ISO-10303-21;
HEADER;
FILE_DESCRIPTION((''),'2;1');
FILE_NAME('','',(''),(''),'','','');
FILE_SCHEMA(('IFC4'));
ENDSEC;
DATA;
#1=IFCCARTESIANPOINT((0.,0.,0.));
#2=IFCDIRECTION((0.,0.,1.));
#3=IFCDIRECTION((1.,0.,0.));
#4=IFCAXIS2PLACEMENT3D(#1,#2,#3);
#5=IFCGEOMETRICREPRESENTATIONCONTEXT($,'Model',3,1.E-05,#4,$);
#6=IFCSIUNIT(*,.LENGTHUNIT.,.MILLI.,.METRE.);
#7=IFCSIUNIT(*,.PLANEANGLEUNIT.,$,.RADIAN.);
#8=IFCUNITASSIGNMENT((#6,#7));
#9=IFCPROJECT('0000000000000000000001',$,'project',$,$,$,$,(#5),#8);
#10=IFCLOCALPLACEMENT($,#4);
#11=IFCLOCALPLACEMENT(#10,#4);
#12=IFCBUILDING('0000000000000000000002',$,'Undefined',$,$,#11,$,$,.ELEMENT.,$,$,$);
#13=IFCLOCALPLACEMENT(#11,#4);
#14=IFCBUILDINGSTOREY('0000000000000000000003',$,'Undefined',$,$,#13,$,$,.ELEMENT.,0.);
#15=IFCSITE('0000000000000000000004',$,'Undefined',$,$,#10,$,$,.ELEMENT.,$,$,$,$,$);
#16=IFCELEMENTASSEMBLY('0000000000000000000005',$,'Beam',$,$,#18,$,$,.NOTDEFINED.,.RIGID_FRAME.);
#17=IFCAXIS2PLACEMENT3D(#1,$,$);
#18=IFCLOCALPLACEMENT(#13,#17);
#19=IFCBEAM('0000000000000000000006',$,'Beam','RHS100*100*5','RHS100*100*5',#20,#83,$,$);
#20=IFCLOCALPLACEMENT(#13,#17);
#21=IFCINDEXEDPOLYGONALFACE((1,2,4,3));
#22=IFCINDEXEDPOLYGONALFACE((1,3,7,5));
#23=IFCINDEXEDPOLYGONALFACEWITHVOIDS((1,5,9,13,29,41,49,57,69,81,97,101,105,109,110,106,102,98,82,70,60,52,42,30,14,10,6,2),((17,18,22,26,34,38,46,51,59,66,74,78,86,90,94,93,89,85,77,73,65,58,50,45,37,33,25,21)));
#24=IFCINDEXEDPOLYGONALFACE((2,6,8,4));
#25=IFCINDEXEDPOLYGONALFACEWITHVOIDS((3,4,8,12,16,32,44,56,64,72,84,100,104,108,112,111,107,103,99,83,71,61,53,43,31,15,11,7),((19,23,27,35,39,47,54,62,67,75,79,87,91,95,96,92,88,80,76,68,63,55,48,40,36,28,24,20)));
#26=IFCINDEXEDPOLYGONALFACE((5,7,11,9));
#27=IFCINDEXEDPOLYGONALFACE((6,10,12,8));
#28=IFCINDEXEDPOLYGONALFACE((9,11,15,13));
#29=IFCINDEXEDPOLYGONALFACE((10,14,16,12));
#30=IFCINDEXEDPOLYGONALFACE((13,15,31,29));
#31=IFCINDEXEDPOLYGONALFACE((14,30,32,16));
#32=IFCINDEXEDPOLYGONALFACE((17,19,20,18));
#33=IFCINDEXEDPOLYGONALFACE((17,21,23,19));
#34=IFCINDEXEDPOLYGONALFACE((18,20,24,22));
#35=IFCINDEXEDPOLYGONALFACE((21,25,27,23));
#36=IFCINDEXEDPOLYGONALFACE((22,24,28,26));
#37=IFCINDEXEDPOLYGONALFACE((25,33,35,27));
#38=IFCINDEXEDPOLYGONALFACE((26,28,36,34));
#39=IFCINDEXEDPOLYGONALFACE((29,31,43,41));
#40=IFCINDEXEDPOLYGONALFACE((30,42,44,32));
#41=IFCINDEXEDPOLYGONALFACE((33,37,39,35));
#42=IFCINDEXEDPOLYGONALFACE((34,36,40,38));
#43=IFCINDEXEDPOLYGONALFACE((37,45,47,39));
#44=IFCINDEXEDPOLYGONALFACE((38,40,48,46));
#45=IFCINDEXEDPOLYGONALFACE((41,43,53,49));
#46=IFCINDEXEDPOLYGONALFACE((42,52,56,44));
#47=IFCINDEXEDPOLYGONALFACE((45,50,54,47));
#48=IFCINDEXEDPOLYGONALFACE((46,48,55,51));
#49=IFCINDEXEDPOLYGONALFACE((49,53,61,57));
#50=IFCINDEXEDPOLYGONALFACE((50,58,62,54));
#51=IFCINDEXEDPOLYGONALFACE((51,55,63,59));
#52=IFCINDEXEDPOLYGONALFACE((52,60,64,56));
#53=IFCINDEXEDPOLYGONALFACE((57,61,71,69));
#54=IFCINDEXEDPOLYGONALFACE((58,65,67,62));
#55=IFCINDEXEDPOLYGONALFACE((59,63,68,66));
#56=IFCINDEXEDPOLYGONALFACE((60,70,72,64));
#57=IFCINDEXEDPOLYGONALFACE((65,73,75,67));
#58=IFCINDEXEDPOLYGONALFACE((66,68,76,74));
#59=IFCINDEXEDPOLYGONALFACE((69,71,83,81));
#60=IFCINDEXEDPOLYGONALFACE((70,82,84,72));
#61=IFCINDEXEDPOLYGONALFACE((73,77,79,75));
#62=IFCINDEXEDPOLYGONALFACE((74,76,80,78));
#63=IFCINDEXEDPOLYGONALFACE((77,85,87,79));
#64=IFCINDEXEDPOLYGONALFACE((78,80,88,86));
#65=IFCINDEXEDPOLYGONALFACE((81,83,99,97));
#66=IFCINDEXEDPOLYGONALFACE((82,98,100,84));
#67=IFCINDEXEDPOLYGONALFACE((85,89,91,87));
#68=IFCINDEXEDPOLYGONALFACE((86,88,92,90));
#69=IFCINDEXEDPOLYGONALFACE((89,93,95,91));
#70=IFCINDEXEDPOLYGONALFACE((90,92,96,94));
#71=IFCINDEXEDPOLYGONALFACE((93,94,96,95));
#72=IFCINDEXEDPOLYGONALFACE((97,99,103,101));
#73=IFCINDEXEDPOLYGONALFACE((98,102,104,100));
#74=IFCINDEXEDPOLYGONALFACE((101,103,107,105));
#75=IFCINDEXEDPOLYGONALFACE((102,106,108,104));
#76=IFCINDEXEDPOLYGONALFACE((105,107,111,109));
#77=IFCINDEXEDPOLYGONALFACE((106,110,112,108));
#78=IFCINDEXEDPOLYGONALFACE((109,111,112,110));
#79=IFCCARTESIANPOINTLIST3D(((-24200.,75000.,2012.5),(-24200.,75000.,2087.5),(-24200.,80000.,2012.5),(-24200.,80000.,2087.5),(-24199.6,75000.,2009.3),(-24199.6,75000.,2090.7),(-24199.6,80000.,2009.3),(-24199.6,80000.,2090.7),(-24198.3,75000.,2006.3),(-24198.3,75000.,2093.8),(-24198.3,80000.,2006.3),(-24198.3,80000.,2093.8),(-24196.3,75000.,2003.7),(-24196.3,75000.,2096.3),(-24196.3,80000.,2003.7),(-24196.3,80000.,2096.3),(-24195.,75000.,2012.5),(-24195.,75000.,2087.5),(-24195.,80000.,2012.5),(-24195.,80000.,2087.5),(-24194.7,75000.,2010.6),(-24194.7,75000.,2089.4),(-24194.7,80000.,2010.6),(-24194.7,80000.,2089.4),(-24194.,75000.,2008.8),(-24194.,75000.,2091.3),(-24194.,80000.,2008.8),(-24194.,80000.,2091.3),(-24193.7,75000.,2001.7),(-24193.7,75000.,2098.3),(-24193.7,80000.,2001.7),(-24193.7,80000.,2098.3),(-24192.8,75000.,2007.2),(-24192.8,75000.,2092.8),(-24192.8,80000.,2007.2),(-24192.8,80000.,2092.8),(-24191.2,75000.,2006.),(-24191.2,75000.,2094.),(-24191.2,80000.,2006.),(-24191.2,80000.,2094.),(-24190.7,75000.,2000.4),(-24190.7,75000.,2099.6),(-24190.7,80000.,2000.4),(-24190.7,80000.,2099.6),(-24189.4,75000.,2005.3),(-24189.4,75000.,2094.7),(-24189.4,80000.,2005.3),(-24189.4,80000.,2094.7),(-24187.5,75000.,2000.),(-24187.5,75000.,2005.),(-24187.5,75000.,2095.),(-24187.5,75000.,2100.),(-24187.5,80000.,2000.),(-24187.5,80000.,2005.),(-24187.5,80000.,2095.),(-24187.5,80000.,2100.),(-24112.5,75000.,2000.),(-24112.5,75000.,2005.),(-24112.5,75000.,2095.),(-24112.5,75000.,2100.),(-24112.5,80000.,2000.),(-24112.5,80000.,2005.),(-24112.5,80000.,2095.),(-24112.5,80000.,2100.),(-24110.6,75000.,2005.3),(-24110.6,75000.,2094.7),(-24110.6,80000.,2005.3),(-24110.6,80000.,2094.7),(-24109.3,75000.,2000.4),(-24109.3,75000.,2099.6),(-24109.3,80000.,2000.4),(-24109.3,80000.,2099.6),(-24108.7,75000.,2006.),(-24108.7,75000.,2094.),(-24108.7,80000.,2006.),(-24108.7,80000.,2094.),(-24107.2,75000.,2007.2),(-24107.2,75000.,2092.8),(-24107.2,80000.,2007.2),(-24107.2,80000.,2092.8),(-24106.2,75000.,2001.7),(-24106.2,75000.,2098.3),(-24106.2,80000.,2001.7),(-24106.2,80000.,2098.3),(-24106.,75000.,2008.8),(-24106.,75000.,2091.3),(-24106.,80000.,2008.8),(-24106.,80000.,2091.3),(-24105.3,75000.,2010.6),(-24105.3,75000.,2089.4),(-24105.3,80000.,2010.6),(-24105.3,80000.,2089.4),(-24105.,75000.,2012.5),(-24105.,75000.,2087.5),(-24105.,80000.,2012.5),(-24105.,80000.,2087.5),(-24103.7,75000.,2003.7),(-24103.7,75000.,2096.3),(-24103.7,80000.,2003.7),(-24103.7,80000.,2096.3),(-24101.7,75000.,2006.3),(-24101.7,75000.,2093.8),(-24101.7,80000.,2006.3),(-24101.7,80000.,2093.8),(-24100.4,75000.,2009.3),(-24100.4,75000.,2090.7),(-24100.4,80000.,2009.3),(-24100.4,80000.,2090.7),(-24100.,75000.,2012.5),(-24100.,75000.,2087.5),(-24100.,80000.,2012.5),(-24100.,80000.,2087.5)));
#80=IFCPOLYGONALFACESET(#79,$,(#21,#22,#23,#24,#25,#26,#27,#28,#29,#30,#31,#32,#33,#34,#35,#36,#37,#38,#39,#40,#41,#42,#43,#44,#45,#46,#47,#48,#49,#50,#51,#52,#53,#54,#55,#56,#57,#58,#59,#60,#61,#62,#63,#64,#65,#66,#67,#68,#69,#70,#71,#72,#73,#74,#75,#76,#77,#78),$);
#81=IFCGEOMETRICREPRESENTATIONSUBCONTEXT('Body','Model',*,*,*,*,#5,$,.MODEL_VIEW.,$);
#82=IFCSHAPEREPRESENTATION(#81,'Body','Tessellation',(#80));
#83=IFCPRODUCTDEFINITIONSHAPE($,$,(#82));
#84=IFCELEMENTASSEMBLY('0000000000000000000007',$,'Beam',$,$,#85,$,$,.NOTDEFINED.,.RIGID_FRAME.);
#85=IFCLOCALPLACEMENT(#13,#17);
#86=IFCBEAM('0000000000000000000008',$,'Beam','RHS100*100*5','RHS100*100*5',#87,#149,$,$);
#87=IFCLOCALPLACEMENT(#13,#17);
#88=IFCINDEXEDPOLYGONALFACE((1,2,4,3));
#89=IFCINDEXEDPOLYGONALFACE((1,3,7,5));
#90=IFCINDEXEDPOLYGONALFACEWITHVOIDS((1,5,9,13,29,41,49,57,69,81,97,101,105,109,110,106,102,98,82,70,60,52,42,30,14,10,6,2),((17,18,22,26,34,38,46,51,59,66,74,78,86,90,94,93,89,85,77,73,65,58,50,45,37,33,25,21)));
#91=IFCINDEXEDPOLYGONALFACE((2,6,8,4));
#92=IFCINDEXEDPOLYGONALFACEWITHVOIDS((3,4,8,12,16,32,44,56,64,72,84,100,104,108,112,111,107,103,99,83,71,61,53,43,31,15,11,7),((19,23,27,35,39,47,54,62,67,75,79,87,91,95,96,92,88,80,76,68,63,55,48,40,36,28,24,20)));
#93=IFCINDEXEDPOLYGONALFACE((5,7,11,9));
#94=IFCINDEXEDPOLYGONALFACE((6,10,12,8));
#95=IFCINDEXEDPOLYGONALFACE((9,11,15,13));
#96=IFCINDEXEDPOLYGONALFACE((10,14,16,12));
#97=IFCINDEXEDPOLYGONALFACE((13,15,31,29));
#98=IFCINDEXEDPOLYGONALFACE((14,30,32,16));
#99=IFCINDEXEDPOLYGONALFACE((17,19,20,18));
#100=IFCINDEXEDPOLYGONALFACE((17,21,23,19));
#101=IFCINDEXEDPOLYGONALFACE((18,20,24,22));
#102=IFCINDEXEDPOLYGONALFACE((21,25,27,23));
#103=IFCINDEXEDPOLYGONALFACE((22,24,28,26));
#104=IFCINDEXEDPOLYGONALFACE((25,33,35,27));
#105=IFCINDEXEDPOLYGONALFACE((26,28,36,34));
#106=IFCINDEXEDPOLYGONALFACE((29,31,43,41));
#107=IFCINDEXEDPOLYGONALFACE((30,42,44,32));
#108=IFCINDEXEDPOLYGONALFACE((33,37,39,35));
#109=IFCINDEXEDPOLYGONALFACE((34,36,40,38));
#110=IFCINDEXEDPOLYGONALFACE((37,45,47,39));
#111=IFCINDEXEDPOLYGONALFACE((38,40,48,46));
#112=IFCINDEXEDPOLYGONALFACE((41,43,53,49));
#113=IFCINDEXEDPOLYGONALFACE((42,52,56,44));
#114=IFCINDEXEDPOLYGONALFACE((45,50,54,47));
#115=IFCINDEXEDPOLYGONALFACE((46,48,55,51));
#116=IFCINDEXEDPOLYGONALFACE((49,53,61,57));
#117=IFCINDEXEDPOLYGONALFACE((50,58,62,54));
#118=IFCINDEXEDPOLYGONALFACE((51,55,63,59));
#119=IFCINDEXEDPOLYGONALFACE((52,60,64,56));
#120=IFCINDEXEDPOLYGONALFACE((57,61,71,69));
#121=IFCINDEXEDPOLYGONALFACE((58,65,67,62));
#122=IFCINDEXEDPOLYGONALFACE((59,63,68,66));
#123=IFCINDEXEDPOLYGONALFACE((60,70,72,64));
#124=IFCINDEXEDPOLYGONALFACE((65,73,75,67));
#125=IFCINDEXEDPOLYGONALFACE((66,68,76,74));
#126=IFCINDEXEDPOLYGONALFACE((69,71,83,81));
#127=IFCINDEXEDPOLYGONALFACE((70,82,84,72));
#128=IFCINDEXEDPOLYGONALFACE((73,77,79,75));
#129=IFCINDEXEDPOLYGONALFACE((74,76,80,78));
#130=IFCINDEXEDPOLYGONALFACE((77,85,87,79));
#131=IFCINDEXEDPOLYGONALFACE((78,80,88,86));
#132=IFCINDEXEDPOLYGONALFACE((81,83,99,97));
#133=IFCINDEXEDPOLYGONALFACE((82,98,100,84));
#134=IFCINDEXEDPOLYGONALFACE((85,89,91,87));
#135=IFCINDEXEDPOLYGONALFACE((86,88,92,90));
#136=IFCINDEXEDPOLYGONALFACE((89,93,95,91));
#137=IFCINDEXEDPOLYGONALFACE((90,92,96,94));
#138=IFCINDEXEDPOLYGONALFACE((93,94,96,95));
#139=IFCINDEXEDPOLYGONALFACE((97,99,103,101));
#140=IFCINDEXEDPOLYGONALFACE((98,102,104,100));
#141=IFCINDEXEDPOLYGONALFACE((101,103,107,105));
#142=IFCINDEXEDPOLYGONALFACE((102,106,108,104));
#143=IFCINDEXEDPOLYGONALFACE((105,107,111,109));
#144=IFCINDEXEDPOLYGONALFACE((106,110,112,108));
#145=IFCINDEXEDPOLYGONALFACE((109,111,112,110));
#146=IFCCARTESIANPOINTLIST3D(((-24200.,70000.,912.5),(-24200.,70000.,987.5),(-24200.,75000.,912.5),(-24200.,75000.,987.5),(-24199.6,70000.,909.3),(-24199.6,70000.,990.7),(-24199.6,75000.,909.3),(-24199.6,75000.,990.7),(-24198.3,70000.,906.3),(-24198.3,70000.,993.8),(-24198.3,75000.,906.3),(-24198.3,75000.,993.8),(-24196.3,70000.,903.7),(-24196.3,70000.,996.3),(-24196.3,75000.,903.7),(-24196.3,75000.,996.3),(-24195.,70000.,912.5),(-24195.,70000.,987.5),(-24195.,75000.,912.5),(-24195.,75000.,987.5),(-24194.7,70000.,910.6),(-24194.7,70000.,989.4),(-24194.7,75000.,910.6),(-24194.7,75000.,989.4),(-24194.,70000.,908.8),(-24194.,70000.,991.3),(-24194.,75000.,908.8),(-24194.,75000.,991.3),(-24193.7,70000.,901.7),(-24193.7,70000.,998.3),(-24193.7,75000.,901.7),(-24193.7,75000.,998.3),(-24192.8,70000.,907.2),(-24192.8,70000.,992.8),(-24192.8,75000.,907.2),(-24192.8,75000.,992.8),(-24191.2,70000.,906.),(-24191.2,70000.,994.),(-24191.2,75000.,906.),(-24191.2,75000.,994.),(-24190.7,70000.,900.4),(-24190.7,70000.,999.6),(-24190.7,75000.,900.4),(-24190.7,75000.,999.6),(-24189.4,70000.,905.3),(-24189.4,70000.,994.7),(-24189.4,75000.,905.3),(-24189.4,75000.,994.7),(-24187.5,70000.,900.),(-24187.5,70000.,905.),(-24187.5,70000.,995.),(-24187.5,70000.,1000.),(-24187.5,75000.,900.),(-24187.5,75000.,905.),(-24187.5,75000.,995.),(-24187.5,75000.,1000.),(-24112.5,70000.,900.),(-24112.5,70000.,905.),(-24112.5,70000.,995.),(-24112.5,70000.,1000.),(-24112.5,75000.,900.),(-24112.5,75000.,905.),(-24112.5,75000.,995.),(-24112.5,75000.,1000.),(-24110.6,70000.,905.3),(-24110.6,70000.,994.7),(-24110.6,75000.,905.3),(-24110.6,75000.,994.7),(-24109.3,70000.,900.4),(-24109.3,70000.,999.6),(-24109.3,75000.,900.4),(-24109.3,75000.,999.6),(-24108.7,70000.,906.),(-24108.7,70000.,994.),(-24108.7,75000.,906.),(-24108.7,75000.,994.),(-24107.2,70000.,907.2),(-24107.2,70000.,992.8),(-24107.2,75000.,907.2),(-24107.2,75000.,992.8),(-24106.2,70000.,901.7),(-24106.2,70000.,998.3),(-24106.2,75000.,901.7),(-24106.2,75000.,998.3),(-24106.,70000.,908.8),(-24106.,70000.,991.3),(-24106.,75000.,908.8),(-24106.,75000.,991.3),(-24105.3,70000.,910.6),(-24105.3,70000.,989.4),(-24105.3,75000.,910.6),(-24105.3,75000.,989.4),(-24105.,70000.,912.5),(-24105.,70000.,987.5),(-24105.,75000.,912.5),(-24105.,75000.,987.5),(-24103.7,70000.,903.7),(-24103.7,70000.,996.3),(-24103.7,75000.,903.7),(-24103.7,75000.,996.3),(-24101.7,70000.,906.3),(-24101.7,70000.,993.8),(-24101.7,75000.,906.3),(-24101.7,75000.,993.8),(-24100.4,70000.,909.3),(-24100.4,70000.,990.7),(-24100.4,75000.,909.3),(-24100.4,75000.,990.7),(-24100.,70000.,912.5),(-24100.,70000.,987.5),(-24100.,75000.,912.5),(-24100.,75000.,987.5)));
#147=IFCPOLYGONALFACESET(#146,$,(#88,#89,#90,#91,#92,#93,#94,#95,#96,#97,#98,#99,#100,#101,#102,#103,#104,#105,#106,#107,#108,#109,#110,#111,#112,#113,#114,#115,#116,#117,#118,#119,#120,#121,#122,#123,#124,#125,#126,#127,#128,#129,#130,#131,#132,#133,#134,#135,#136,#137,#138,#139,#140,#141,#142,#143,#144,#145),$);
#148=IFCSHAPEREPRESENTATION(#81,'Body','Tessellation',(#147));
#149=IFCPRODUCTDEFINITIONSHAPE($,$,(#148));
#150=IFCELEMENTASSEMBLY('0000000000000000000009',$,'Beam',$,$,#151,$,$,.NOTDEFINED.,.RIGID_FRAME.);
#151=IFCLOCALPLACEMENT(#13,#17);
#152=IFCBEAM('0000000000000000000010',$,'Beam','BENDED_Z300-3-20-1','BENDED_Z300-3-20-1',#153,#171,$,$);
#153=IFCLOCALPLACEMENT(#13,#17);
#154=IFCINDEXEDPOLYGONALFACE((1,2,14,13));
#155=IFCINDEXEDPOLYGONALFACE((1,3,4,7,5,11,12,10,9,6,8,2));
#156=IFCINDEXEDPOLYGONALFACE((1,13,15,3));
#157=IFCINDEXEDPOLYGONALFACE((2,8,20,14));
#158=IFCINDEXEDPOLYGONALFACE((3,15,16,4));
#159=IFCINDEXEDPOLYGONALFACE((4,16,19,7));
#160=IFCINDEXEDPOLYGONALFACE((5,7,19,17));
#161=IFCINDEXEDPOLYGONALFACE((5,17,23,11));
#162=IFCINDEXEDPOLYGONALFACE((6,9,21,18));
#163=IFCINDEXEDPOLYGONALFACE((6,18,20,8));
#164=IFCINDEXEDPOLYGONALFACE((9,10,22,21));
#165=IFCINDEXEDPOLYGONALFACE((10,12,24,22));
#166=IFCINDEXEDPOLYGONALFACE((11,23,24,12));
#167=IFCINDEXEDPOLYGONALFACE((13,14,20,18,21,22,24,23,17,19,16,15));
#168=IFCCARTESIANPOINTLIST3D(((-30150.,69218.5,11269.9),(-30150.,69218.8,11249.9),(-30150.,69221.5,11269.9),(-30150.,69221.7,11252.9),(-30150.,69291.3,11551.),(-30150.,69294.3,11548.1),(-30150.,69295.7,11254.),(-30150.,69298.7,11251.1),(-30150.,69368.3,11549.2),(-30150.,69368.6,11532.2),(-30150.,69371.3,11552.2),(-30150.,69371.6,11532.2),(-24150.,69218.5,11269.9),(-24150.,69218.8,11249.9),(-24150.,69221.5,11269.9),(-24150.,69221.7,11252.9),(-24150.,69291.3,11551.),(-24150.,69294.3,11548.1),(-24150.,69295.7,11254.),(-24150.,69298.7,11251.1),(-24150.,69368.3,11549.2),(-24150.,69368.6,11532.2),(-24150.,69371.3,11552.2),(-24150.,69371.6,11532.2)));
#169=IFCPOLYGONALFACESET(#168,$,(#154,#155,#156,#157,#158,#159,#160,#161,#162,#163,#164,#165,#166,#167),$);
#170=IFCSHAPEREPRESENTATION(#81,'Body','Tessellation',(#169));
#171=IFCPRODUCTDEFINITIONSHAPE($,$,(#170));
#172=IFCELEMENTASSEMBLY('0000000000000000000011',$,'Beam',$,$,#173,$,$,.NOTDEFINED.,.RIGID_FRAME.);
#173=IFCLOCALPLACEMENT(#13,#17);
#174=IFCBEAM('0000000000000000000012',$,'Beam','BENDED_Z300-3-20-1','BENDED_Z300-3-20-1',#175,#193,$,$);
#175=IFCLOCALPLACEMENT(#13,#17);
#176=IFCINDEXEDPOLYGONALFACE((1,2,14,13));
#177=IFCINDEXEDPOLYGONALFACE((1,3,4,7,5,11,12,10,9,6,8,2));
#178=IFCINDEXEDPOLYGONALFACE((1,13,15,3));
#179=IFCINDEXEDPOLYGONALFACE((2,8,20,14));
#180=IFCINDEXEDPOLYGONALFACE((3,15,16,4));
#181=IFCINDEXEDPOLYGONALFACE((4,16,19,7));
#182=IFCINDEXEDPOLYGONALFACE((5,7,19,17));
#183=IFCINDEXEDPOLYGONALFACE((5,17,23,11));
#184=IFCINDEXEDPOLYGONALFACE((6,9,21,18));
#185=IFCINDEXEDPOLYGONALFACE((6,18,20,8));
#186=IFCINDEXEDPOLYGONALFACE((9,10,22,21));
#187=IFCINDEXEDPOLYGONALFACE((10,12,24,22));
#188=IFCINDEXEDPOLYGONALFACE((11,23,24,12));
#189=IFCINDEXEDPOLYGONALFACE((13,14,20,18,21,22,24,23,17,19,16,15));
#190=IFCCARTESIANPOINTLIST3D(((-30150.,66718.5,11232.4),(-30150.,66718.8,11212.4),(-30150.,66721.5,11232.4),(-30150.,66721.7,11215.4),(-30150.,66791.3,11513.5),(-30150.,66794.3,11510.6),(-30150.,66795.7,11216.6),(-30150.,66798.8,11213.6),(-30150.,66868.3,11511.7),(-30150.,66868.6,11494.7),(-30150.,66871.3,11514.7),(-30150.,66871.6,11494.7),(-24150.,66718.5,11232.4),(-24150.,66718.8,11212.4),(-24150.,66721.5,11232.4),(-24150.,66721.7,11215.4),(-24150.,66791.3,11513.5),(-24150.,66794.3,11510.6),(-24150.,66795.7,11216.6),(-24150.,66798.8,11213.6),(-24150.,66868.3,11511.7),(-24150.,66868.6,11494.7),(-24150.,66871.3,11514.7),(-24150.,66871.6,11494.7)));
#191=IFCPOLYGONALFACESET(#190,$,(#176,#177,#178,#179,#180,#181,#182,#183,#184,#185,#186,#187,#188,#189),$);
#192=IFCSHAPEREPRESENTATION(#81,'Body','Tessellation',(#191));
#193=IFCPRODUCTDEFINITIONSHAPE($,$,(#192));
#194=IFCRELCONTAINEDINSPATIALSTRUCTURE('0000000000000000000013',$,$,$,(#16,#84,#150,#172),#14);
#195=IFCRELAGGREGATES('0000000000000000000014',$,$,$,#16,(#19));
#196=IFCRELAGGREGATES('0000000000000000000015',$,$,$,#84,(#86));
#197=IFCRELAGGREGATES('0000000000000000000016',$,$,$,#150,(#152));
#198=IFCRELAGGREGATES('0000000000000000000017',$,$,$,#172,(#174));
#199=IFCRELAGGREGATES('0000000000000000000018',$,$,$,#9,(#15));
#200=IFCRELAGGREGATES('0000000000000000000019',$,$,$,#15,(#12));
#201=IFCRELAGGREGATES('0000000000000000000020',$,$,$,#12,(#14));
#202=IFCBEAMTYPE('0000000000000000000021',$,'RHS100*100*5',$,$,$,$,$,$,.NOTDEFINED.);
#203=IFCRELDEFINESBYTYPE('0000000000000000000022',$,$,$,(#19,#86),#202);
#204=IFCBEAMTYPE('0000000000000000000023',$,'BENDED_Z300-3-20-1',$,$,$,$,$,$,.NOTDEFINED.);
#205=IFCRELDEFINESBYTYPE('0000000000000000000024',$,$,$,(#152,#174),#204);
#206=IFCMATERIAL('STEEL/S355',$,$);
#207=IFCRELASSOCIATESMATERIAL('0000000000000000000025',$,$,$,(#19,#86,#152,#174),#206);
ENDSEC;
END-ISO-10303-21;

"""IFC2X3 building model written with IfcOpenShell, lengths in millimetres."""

from ifc_helpers import new_model, si_unit, frame, origin_with_axes, origin_2d_with_axis, place, context, subcontext, project, spatial, polyline, hollow_rectangle, outline, extrude, material, type_object, element, aggregate, save


model = new_model("IFC2X3")

# Units and contexts
model_context = context("Model", 3, precision=1e-05, world=origin_with_axes())
body_context = subcontext(model_context, "Body", "Model", "MODEL_VIEW")
ifc_project = project(units=[si_unit("LENGTHUNIT", "METRE", prefix="MILLI"), si_unit("PLANEANGLEUNIT", "RADIAN")], contexts=[model_context])

# Site, building, storey
site_placement = place(None, origin_with_axes())
site = spatial("IfcSite", under=ifc_project, at=site_placement, Name="Undefined", CompositionType="ELEMENT")
building_placement = place(site_placement, origin_with_axes())
building = spatial("IfcBuilding", under=site, at=building_placement, Name="Undefined", CompositionType="ELEMENT")
storey_placement = place(building_placement, origin_with_axes())
storey = spatial("IfcBuildingStorey", under=building, at=storey_placement, Name="Undefined", CompositionType="ELEMENT", Elevation=0.0)

# Element assemblies, beams
ifc_material_1 = material(Name="STEEL/S355")
beam_type_1 = type_object("IfcBeamType", Name="RHS100*100*5", PredefinedType="NOTDEFINED")
assembly_1_placement = place(storey_placement, origin_with_axes())
assembly_1 = element("IfcElementAssembly", 1, at=assembly_1_placement, inside=storey, Name="Beam", AssemblyPlace="NOTDEFINED", PredefinedType="RIGID_FRAME")
beam_1_placement = place(assembly_1_placement, frame((-24150.0, 75000.0, 2050.0), z_axis=(0.0, 0.0, 1.0), x_axis=(0.0, 1.0, 0.0)))
beam_1 = element("IfcBeam", 2, at=beam_1_placement, type_object=beam_type_1, material=ifc_material_1, Name="Beam", Description="RHS100*100*5", ObjectType="RHS100*100*5", context=body_context, shape_type="SweptSolid", body=[
    extrude(hollow_rectangle(XDim=100.0, YDim=100.0, WallThickness=5.0, InnerFilletRadius=7.5, OuterFilletRadius=12.5, at=origin_2d_with_axis()), frame((5000.0, 0.0, 0.0), z_axis=(-1.0, 0.0, 0.0), x_axis=(0.0, -1.0, 0.0)), (0.0, 0.0, 1.0), 5000.0),
])
aggregate(assembly_1, [beam_1])
assembly_2_placement = place(storey_placement, origin_with_axes())
assembly_2 = element("IfcElementAssembly", 3, at=assembly_2_placement, inside=storey, Name="Beam", AssemblyPlace="NOTDEFINED", PredefinedType="RIGID_FRAME")
beam_2_placement = place(assembly_2_placement, frame((-24150.0, 70000.0, 950.0), z_axis=(0.0, 0.0, 1.0), x_axis=(0.0, 1.0, 0.0)))
beam_2 = element("IfcBeam", 4, at=beam_2_placement, type_object=beam_type_1, material=ifc_material_1, Name="Beam", Description="RHS100*100*5", ObjectType="RHS100*100*5", context=body_context, shape_type="SweptSolid", body=[
    extrude(hollow_rectangle(XDim=100.0, YDim=100.0, WallThickness=5.0, InnerFilletRadius=7.5, OuterFilletRadius=12.5, at=origin_2d_with_axis()), frame((5000.0, 0.0, 0.0), z_axis=(-1.0, 0.0, 0.0), x_axis=(0.0, -1.0, 0.0)), (0.0, 0.0, 1.0), 5000.0),
])
aggregate(assembly_2, [beam_2])
assembly_3_placement = place(storey_placement, origin_with_axes())
assembly_3 = element("IfcElementAssembly", 5, at=assembly_3_placement, inside=storey, Name="Beam", AssemblyPlace="NOTDEFINED", PredefinedType="RIGID_FRAME")
beam_type_2 = type_object("IfcBeamType", Name="BENDED_Z300-3-20-1", PredefinedType="NOTDEFINED")
beam_3_placement = place(assembly_3_placement, frame((-24150.0, 69295.0, 11401.1), z_axis=(0.0, -0.014963, 0.999888), x_axis=(-1.0, 0.0, 0.0)))
beam_3 = element("IfcBeam", 6, at=beam_3_placement, type_object=beam_type_2, material=ifc_material_1, Name="Beam", Description="BENDED_Z300-3-20-1", ObjectType="BENDED_Z300-3-20-1", context=body_context, shape_type="SweptSolid", body=[
    extrude(outline(polyline([(1.5, -150.0), (-78.5, -150.0), (-78.5, -130.0), (-75.5, -130.0), (-75.5, -147.0), (-1.5, -147.0), (-1.5, 150.0), (78.5, 150.0), (78.5, 130.0), (75.5, 130.0), (75.5, 147.0), (1.5, 147.0), (1.5, -150.0)])), frame((6000.0, 0.0, 0.0), z_axis=(-1.0, 0.0, 0.0), x_axis=(0.0, -1.0, 0.0)), (0.0, 0.0, 1.0), 6000.0),
])
aggregate(assembly_3, [beam_3])
assembly_4_placement = place(storey_placement, origin_with_axes())
assembly_4 = element("IfcElementAssembly", 7, at=assembly_4_placement, inside=storey, Name="Beam", AssemblyPlace="NOTDEFINED", PredefinedType="RIGID_FRAME")
beam_4_placement = place(assembly_4_placement, frame((-24150.0, 66795.0, 11363.6), z_axis=(0.0, -0.014963, 0.999888), x_axis=(-1.0, 0.0, 0.0)))
beam_4 = element("IfcBeam", 8, at=beam_4_placement, type_object=beam_type_2, material=ifc_material_1, Name="Beam", Description="BENDED_Z300-3-20-1", ObjectType="BENDED_Z300-3-20-1", context=body_context, shape_type="SweptSolid", body=[
    extrude(outline(polyline([(1.5, -150.0), (-78.5, -150.0), (-78.5, -130.0), (-75.5, -130.0), (-75.5, -147.0), (-1.5, -147.0), (-1.5, 150.0), (78.5, 150.0), (78.5, 130.0), (75.5, 130.0), (75.5, 147.0), (1.5, 147.0), (1.5, -150.0)])), frame((6000.0, 0.0, 0.0), z_axis=(-1.0, 0.0, 0.0), x_axis=(0.0, -1.0, 0.0)), (0.0, 0.0, 1.0), 6000.0),
])
aggregate(assembly_4, [beam_4])

save(model, "model.ifc")
